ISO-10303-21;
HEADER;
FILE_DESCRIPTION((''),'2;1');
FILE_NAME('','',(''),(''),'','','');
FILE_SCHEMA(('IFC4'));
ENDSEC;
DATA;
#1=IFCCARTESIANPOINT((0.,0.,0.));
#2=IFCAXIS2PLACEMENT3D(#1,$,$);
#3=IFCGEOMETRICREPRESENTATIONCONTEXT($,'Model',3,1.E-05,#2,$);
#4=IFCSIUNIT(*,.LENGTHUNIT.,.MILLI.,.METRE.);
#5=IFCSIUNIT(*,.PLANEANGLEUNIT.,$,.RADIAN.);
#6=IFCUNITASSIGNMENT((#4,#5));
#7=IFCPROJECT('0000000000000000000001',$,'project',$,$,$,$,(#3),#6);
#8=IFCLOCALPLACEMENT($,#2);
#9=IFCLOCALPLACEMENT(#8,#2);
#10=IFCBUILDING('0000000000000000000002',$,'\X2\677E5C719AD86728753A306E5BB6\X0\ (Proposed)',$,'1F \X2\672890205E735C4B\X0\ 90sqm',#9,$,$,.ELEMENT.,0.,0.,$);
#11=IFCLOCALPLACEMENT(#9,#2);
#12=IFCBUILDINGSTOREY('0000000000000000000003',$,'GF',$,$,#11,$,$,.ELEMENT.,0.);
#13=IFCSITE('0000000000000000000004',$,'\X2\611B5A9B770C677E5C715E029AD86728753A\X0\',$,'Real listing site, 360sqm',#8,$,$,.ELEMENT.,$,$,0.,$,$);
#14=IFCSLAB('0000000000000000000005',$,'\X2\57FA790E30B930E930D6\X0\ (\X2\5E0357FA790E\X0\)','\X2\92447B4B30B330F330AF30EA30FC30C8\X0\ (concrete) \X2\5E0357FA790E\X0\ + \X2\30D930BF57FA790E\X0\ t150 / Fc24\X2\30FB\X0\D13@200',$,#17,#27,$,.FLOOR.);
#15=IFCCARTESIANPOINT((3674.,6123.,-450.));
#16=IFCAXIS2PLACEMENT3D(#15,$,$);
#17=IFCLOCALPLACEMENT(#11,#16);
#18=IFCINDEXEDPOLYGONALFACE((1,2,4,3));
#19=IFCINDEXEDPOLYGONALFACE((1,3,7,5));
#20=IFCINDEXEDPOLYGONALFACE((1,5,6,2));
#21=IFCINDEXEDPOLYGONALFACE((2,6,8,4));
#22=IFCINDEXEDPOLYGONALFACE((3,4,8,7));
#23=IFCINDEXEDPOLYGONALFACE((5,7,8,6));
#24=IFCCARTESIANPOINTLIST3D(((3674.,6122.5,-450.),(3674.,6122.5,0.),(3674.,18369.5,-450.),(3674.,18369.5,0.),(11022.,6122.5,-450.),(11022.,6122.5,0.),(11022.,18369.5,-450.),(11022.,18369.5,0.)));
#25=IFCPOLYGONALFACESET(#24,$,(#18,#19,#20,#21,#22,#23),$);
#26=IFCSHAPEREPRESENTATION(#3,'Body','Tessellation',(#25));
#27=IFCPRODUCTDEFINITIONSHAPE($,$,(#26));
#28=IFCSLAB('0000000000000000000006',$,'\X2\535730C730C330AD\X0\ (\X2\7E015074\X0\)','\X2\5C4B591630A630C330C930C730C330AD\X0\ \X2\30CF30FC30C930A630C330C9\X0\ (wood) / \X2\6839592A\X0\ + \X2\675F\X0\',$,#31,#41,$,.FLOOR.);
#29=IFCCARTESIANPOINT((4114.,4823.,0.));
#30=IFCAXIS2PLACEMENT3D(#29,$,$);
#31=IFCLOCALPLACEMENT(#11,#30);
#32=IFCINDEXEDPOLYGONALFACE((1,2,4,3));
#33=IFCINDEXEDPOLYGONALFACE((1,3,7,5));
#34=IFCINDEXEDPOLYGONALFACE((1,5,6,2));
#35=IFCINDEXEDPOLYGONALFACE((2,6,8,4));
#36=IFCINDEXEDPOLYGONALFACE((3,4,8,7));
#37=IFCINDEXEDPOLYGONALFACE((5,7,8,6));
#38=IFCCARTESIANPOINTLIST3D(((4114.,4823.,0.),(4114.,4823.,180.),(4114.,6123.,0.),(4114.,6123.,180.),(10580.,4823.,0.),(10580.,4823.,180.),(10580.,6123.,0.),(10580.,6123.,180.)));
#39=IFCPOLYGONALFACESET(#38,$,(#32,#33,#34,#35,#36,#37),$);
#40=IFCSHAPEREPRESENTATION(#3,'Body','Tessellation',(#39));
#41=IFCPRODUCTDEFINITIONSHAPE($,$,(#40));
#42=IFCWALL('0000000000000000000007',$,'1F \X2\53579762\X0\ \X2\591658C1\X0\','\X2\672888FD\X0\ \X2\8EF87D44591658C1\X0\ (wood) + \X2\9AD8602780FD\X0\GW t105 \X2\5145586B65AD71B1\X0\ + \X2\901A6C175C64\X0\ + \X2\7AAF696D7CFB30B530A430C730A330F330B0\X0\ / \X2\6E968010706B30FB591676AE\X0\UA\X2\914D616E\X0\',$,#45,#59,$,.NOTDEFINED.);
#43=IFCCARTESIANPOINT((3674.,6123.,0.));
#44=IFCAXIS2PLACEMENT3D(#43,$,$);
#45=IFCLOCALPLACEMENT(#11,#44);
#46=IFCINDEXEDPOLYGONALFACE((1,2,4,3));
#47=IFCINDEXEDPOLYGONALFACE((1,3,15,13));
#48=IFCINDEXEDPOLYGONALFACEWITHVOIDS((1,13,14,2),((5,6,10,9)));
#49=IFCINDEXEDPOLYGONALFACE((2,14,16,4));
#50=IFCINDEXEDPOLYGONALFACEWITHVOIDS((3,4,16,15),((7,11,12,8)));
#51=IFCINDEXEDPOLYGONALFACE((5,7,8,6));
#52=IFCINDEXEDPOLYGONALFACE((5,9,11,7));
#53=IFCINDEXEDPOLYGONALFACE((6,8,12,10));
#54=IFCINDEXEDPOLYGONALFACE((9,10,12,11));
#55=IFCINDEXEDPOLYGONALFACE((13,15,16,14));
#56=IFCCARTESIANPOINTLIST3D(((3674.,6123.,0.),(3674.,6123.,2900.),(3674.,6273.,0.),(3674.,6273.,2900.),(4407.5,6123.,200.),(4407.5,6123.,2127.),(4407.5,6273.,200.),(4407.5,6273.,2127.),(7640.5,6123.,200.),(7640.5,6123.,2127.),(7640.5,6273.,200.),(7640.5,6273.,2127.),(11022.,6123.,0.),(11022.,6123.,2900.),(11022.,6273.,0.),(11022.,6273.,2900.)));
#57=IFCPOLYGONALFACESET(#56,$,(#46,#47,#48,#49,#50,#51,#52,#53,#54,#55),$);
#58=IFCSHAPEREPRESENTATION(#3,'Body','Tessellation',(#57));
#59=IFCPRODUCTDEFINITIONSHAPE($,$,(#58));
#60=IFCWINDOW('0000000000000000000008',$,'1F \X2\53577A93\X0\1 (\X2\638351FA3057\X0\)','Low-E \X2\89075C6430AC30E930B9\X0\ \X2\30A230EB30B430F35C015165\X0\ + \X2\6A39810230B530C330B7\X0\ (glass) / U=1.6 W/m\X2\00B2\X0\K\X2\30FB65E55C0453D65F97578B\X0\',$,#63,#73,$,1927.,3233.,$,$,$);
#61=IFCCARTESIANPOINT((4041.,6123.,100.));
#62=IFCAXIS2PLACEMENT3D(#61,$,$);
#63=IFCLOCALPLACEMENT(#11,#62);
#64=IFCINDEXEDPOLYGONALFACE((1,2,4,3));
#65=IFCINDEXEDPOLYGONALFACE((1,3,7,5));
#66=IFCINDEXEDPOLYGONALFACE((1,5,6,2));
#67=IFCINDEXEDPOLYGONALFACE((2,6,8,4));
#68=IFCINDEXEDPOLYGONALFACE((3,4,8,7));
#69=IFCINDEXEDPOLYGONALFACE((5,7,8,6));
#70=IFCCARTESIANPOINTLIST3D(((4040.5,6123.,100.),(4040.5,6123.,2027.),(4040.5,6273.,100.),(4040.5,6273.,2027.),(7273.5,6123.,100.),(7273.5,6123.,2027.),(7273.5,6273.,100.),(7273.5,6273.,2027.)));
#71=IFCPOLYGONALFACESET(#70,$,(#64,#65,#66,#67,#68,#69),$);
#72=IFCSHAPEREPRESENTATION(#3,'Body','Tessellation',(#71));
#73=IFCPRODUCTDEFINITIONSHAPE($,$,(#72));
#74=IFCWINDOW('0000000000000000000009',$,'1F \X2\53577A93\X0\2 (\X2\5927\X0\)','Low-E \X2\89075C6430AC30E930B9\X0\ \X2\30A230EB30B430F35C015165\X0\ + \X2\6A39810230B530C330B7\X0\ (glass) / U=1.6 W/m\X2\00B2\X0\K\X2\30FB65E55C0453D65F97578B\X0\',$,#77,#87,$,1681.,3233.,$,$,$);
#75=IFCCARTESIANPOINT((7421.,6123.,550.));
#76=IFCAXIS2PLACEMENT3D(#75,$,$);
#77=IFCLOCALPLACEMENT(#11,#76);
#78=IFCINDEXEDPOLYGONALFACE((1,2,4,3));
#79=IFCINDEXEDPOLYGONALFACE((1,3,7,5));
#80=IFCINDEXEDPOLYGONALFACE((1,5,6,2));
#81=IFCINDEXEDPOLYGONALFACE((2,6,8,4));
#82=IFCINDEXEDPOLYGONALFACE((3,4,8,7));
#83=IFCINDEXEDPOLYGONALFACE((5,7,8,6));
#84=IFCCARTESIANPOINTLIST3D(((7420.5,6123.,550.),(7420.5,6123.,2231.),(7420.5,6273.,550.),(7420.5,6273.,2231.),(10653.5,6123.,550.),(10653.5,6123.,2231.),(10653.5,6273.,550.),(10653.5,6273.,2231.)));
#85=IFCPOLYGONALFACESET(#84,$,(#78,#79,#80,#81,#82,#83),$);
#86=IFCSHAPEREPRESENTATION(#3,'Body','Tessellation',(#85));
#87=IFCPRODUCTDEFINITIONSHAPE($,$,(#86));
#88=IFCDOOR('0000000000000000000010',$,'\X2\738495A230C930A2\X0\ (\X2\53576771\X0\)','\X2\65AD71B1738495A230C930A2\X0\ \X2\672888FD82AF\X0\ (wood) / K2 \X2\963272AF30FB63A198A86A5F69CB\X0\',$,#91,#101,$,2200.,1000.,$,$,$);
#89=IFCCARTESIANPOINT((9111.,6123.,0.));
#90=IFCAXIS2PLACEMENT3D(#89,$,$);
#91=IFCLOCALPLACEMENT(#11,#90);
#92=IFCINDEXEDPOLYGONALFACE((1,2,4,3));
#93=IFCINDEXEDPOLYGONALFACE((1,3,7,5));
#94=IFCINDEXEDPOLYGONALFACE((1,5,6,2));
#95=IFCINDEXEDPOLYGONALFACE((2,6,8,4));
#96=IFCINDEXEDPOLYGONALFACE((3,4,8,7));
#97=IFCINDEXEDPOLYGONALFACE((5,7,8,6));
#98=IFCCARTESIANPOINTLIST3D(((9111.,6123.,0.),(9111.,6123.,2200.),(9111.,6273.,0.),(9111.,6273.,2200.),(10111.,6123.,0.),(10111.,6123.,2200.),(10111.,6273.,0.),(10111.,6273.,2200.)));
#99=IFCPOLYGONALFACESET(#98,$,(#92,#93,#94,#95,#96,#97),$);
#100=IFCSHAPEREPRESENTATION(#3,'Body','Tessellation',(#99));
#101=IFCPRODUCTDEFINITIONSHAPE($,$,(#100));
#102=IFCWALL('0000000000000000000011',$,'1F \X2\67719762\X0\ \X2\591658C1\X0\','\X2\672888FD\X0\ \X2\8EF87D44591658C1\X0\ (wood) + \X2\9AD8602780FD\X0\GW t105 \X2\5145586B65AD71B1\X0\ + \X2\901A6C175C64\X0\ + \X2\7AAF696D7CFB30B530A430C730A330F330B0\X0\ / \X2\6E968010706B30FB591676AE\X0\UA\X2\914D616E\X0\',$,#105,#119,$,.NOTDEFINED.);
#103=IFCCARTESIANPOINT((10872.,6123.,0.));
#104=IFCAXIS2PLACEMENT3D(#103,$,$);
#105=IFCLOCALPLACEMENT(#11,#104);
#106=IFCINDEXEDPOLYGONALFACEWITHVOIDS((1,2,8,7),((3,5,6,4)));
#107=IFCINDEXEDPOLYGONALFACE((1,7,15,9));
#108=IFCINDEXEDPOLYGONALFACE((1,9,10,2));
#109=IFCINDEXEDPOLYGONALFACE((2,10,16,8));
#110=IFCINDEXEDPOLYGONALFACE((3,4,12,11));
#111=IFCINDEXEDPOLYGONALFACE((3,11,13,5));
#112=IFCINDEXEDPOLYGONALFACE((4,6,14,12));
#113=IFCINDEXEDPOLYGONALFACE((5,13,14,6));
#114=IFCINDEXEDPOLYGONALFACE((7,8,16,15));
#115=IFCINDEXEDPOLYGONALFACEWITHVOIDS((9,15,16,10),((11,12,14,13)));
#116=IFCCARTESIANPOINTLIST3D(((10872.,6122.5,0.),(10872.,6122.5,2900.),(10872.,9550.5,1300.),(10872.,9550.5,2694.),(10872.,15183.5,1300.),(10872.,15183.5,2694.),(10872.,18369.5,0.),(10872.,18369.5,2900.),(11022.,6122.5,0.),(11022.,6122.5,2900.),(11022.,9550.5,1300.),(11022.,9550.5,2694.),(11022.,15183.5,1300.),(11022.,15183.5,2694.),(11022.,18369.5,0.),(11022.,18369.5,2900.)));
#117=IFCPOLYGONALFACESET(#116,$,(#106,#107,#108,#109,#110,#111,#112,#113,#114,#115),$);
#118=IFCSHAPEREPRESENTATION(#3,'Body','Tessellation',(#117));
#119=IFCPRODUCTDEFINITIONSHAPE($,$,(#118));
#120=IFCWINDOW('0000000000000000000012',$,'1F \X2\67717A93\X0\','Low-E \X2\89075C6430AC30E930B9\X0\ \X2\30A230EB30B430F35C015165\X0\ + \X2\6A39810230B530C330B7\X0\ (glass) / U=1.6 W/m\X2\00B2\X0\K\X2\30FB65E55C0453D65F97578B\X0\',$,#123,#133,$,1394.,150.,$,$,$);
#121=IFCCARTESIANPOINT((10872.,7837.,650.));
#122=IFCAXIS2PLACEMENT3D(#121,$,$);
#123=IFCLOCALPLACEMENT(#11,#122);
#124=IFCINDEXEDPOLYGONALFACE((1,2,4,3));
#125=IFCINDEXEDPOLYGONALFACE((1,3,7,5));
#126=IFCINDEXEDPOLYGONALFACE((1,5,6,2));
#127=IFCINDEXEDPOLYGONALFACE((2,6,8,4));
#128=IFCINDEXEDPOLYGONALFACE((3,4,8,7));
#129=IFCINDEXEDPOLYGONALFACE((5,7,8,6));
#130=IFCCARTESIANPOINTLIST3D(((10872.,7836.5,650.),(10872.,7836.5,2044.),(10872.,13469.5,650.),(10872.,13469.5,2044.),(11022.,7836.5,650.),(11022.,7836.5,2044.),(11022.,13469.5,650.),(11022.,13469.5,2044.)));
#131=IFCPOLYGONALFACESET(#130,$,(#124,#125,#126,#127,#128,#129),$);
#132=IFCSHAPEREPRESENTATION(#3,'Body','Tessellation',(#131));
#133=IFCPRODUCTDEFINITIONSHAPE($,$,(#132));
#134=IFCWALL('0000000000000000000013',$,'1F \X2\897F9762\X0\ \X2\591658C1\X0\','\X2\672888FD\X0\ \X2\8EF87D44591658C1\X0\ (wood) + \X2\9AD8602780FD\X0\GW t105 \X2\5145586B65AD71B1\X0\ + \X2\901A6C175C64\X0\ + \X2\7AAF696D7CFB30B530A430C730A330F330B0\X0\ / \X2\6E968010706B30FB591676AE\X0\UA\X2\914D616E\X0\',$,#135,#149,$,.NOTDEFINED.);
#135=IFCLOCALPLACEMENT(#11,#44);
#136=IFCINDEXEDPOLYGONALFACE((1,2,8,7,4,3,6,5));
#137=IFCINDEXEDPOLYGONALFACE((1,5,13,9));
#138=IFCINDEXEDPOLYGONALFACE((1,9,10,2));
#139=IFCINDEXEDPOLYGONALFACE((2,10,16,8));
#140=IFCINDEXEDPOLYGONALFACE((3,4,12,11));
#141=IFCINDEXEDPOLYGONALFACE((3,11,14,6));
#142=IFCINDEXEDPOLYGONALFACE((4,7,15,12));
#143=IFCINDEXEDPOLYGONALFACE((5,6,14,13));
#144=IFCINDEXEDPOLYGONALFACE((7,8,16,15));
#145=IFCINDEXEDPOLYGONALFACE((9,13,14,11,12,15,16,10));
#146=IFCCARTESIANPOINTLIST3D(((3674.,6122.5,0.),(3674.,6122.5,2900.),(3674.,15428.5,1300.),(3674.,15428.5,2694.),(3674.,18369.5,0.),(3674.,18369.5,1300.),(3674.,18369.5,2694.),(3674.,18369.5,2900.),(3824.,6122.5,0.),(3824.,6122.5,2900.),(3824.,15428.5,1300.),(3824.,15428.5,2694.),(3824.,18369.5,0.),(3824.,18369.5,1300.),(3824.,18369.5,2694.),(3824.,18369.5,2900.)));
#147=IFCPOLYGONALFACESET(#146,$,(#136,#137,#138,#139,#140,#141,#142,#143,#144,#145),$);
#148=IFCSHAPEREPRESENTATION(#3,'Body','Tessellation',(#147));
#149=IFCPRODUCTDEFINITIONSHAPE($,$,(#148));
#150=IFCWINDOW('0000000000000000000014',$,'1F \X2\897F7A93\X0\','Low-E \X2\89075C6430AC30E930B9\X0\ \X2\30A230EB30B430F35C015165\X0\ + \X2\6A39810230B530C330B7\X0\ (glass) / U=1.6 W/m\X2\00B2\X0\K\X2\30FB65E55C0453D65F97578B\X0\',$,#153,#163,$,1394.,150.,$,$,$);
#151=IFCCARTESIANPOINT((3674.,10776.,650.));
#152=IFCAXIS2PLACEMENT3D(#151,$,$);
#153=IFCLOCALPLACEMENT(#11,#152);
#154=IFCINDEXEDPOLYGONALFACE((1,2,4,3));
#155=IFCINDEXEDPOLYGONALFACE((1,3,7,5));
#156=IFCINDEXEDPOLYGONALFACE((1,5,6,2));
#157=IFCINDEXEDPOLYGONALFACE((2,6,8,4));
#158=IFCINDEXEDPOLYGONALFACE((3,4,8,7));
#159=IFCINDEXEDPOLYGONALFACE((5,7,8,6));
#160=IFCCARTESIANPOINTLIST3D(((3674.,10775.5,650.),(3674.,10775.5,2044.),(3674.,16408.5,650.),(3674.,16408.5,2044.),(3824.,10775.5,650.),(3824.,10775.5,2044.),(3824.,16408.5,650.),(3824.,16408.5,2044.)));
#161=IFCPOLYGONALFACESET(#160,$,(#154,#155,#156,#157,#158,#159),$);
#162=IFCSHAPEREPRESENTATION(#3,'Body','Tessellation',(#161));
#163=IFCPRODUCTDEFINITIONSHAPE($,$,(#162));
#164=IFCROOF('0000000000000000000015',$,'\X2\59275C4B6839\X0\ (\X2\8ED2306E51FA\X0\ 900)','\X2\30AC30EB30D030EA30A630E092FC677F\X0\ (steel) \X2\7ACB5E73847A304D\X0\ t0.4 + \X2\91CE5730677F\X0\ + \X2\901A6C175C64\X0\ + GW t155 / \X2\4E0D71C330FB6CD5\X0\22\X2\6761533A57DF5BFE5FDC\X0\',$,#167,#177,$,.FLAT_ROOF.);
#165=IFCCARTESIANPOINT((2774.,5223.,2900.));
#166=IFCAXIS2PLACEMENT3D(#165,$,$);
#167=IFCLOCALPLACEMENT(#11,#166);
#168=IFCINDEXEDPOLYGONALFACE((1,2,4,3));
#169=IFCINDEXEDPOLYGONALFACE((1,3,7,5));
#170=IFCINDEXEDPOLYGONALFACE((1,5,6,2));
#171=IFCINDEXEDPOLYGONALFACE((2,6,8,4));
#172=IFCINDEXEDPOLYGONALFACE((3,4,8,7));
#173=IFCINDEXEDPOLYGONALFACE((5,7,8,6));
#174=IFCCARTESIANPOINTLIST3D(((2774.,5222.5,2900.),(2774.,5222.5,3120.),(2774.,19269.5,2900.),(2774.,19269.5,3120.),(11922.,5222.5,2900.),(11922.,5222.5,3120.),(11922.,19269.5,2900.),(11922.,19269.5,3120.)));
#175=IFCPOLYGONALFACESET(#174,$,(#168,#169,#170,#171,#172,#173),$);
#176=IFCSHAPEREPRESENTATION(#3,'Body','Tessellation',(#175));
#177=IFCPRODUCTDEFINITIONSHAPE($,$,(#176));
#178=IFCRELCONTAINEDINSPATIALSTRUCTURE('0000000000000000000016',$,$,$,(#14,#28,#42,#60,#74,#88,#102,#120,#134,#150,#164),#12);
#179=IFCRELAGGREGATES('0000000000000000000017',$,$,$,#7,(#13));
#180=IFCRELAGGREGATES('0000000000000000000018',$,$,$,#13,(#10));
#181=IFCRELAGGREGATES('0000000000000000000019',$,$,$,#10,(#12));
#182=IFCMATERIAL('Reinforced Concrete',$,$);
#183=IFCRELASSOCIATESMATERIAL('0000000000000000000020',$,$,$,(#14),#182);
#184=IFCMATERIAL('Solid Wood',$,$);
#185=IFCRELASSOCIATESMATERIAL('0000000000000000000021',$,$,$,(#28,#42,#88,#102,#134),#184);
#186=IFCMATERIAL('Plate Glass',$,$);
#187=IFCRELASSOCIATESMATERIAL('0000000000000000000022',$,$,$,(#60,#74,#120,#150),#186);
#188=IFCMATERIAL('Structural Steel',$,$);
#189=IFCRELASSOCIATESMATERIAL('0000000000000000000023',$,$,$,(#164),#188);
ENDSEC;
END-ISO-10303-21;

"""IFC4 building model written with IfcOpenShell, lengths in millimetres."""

from ifc_helpers import new_model, si_unit, frame, frame_2d, origin, place, context, project, spatial, rectangle, extrude, material, element, fill, save


model = new_model("IFC4")

# Units and contexts
model_context = context("Model", 3, precision=1e-05, world=origin())
ifc_project = project(units=[si_unit("LENGTHUNIT", "METRE", prefix="MILLI"), si_unit("PLANEANGLEUNIT", "RADIAN")], contexts=[model_context])

# Site, building, storey
site_placement = place(None, origin())
site = spatial("IfcSite", under=ifc_project, at=site_placement, Name="愛媛県松山市高木町", ObjectType="Real listing site, 360sqm", CompositionType="ELEMENT", RefElevation=0.0)
building_placement = place(site_placement, origin())
building = spatial("IfcBuilding", under=site, at=building_placement, Name="松山高木町の家 (Proposed)", ObjectType="1F 木造平屋 90sqm", CompositionType="ELEMENT", ElevationOfRefHeight=0.0, ElevationOfTerrain=0.0)
storey_placement = place(building_placement, origin())
storey = spatial("IfcBuildingStorey", under=building, at=storey_placement, Name="GF", CompositionType="ELEMENT", Elevation=0.0)

# Slabs
ifc_material_1 = material(Name="Reinforced Concrete")
slab_1_placement = place(storey_placement, frame((3674.0, 6123.0, -450.0)))
element("IfcSlab", 1, at=slab_1_placement, inside=storey, material=ifc_material_1, Name="基礎スラブ (布基礎)", Description="鉄筋コンクリート (concrete) 布基礎 + ベタ基礎 t150 / Fc24・D13@200", PredefinedType="FLOOR", context=model_context, shape_type="SweptSolid", body=[
    extrude(rectangle(XDim=7348.0, YDim=12247.0, at=frame_2d((3674.0, 6123.0))), frame((3674.0, 6123.0, -450.0)), (0.0, 0.0, 1.0), 450.0),
])
ifc_material_2 = material(Name="Solid Wood")
slab_2_placement = place(storey_placement, frame((4114.0, 4823.0, 0.0)))
element("IfcSlab", 2, at=slab_2_placement, inside=storey, material=ifc_material_2, Name="南デッキ (縁側)", Description="屋外ウッドデッキ ハードウッド (wood) / 根太 + 束", PredefinedType="FLOOR", context=model_context, shape_type="SweptSolid", body=[
    extrude(rectangle(XDim=6466.0, YDim=1300.0, at=frame_2d((3233.0, 650.0))), frame((4114.0, 4823.0, 0.0)), (0.0, 0.0, 1.0), 180.0),
])

# Wall, openings, windows, door
wall_1_placement = place(storey_placement, frame((3674.0, 6123.0, 0.0)))
wall_1 = element("IfcWall", 3, at=wall_1_placement, inside=storey, material=ifc_material_2, Name="1F 南面 外壁", Description="木製 軸組外壁 (wood) + 高性能GW t105 充填断熱 + 通気層 + 窯業系サイディング / 準耐火・外皮UA配慮", PredefinedType="NOTDEFINED", context=model_context, shape_type="SweptSolid", body=[
    extrude(rectangle(XDim=7348.0, YDim=150.0, at=frame_2d((3674.0, 75.0))), frame((3674.0, 6123.0, 0.0)), (0.0, 0.0, 1.0), 2900.0),
])
opening_1_placement = place(storey_placement, frame((4041.0, 6123.0, 100.0)))
opening_1 = element("IfcOpeningElement", 4, at=opening_1_placement, cuts=wall_1, PredefinedType="NOTDEFINED", context=model_context, shape_type="SweptSolid", body=[
    extrude(rectangle(XDim=3233.0, YDim=150.0, at=frame_2d((1616.0, 75.0))), frame((4041.0, 6123.0, 100.0)), (0.0, 0.0, 1.0), 1927.0),
])
opening_2_placement = place(storey_placement, frame((7421.0, 6123.0, 550.0)))
opening_2 = element("IfcOpeningElement", 5, at=opening_2_placement, cuts=wall_1, PredefinedType="NOTDEFINED", context=model_context, shape_type="SweptSolid", body=[
    extrude(rectangle(XDim=3233.0, YDim=150.0, at=frame_2d((1616.0, 75.0))), frame((7421.0, 6123.0, 550.0)), (0.0, 0.0, 1.0), 1681.0),
])
opening_3_placement = place(storey_placement, frame((9111.0, 6123.0, 0.0)))
opening_3 = element("IfcOpeningElement", 6, at=opening_3_placement, cuts=wall_1, PredefinedType="NOTDEFINED", context=model_context, shape_type="SweptSolid", body=[
    extrude(rectangle(XDim=1000.0, YDim=150.0, at=frame_2d((500.0, 75.0))), frame((9111.0, 6123.0, 0.0)), (0.0, 0.0, 1.0), 2200.0),
])
ifc_material_3 = material(Name="Plate Glass")
window_1_placement = place(storey_placement, frame((4041.0, 6123.0, 100.0)))
window_1 = element("IfcWindow", 7, at=window_1_placement, inside=storey, material=ifc_material_3, Name="1F 南窓1 (掃出し)", Description="Low-E 複層ガラス アルゴン封入 + 樹脂サッシ (glass) / U=1.6 W/m²K・日射取得型", OverallHeight=1927.0, OverallWidth=3233.0, context=model_context, shape_type="SweptSolid", body=[
    extrude(rectangle(XDim=3233.0, YDim=150.0, at=frame_2d((1616.0, 75.0))), frame((4041.0, 6123.0, 100.0)), (0.0, 0.0, 1.0), 1927.0),
])
fill(opening_1, window_1)
window_2_placement = place(storey_placement, frame((7421.0, 6123.0, 550.0)))
window_2 = element("IfcWindow", 8, at=window_2_placement, inside=storey, material=ifc_material_3, Name="1F 南窓2 (大)", Description="Low-E 複層ガラス アルゴン封入 + 樹脂サッシ (glass) / U=1.6 W/m²K・日射取得型", OverallHeight=1681.0, OverallWidth=3233.0, context=model_context, shape_type="SweptSolid", body=[
    extrude(rectangle(XDim=3233.0, YDim=150.0, at=frame_2d((1616.0, 75.0))), frame((7421.0, 6123.0, 550.0)), (0.0, 0.0, 1.0), 1681.0),
])
fill(opening_2, window_2)
door_placement = place(storey_placement, frame((9111.0, 6123.0, 0.0)))
door = element("IfcDoor", 9, at=door_placement, inside=storey, material=ifc_material_2, Name="玄関ドア (南東)", Description="断熱玄関ドア 木製芯 (wood) / K2 防犯・採風機構", OverallHeight=2200.0, OverallWidth=1000.0, context=model_context, shape_type="SweptSolid", body=[
    extrude(rectangle(XDim=1000.0, YDim=150.0, at=frame_2d((500.0, 75.0))), frame((9111.0, 6123.0, 0.0)), (0.0, 0.0, 1.0), 2200.0),
])
fill(opening_3, door)

# Walls, openings, windows
wall_2_placement = place(storey_placement, frame((10872.0, 6123.0, 0.0)))
wall_2 = element("IfcWall", 10, at=wall_2_placement, inside=storey, material=ifc_material_2, Name="1F 東面 外壁", Description="木製 軸組外壁 (wood) + 高性能GW t105 充填断熱 + 通気層 + 窯業系サイディング / 準耐火・外皮UA配慮", PredefinedType="NOTDEFINED", context=model_context, shape_type="SweptSolid", body=[
    extrude(rectangle(XDim=150.0, YDim=12247.0, at=frame_2d((75.0, 6123.0))), frame((10872.0, 6123.0, 0.0)), (0.0, 0.0, 1.0), 2900.0),
])
opening_4_placement = place(storey_placement, frame((10872.0, 7837.0, 650.0)))
opening_4 = element("IfcOpeningElement", 11, at=opening_4_placement, cuts=wall_2, PredefinedType="NOTDEFINED", context=model_context, shape_type="SweptSolid", body=[
    extrude(rectangle(XDim=150.0, YDim=5633.0, at=frame_2d((75.0, 2816.0))), frame((10872.0, 7837.0, 650.0)), (0.0, 0.0, 1.0), 1394.0),
])
window_3_placement = place(storey_placement, frame((10872.0, 7837.0, 650.0)))
window_3 = element("IfcWindow", 12, at=window_3_placement, inside=storey, material=ifc_material_3, Name="1F 東窓", Description="Low-E 複層ガラス アルゴン封入 + 樹脂サッシ (glass) / U=1.6 W/m²K・日射取得型", OverallHeight=1394.0, OverallWidth=150.0, context=model_context, shape_type="SweptSolid", body=[
    extrude(rectangle(XDim=150.0, YDim=5633.0, at=frame_2d((75.0, 2816.0))), frame((10872.0, 7837.0, 650.0)), (0.0, 0.0, 1.0), 1394.0),
])
fill(opening_4, window_3)
wall_3_placement = place(storey_placement, frame((3674.0, 6123.0, 0.0)))
wall_3 = element("IfcWall", 13, at=wall_3_placement, inside=storey, material=ifc_material_2, Name="1F 西面 外壁", Description="木製 軸組外壁 (wood) + 高性能GW t105 充填断熱 + 通気層 + 窯業系サイディング / 準耐火・外皮UA配慮", PredefinedType="NOTDEFINED", context=model_context, shape_type="SweptSolid", body=[
    extrude(rectangle(XDim=150.0, YDim=12247.0, at=frame_2d((75.0, 6123.0))), frame((3674.0, 6123.0, 0.0)), (0.0, 0.0, 1.0), 2900.0),
])
opening_5_placement = place(storey_placement, frame((3674.0, 10776.0, 650.0)))
opening_5 = element("IfcOpeningElement", 14, at=opening_5_placement, cuts=wall_3, PredefinedType="NOTDEFINED", context=model_context, shape_type="SweptSolid", body=[
    extrude(rectangle(XDim=150.0, YDim=5633.0, at=frame_2d((75.0, 2816.0))), frame((3674.0, 10776.0, 650.0)), (0.0, 0.0, 1.0), 1394.0),
])
window_4_placement = place(storey_placement, frame((3674.0, 10776.0, 650.0)))
window_4 = element("IfcWindow", 15, at=window_4_placement, inside=storey, material=ifc_material_3, Name="1F 西窓", Description="Low-E 複層ガラス アルゴン封入 + 樹脂サッシ (glass) / U=1.6 W/m²K・日射取得型", OverallHeight=1394.0, OverallWidth=150.0, context=model_context, shape_type="SweptSolid", body=[
    extrude(rectangle(XDim=150.0, YDim=5633.0, at=frame_2d((75.0, 2816.0))), frame((3674.0, 10776.0, 650.0)), (0.0, 0.0, 1.0), 1394.0),
])
fill(opening_5, window_4)

# Roof
ifc_material_4 = material(Name="Structural Steel")
roof_placement = place(storey_placement, frame((2774.0, 5223.0, 2900.0)))
element("IfcRoof", 16, at=roof_placement, inside=storey, material=ifc_material_4, Name="大屋根 (軒の出 900)", Description="ガルバリウム鋼板 (steel) 立平葺き t0.4 + 野地板 + 通気層 + GW t155 / 不燃・法22条区域対応", PredefinedType="FLAT_ROOF", context=model_context, shape_type="SweptSolid", body=[
    extrude(rectangle(XDim=9148.0, YDim=14047.0, at=frame_2d((4574.0, 7023.0))), frame((2774.0, 5223.0, 2900.0)), (0.0, 0.0, 1.0), 220.0),
])

save(model, "model.ifc")
